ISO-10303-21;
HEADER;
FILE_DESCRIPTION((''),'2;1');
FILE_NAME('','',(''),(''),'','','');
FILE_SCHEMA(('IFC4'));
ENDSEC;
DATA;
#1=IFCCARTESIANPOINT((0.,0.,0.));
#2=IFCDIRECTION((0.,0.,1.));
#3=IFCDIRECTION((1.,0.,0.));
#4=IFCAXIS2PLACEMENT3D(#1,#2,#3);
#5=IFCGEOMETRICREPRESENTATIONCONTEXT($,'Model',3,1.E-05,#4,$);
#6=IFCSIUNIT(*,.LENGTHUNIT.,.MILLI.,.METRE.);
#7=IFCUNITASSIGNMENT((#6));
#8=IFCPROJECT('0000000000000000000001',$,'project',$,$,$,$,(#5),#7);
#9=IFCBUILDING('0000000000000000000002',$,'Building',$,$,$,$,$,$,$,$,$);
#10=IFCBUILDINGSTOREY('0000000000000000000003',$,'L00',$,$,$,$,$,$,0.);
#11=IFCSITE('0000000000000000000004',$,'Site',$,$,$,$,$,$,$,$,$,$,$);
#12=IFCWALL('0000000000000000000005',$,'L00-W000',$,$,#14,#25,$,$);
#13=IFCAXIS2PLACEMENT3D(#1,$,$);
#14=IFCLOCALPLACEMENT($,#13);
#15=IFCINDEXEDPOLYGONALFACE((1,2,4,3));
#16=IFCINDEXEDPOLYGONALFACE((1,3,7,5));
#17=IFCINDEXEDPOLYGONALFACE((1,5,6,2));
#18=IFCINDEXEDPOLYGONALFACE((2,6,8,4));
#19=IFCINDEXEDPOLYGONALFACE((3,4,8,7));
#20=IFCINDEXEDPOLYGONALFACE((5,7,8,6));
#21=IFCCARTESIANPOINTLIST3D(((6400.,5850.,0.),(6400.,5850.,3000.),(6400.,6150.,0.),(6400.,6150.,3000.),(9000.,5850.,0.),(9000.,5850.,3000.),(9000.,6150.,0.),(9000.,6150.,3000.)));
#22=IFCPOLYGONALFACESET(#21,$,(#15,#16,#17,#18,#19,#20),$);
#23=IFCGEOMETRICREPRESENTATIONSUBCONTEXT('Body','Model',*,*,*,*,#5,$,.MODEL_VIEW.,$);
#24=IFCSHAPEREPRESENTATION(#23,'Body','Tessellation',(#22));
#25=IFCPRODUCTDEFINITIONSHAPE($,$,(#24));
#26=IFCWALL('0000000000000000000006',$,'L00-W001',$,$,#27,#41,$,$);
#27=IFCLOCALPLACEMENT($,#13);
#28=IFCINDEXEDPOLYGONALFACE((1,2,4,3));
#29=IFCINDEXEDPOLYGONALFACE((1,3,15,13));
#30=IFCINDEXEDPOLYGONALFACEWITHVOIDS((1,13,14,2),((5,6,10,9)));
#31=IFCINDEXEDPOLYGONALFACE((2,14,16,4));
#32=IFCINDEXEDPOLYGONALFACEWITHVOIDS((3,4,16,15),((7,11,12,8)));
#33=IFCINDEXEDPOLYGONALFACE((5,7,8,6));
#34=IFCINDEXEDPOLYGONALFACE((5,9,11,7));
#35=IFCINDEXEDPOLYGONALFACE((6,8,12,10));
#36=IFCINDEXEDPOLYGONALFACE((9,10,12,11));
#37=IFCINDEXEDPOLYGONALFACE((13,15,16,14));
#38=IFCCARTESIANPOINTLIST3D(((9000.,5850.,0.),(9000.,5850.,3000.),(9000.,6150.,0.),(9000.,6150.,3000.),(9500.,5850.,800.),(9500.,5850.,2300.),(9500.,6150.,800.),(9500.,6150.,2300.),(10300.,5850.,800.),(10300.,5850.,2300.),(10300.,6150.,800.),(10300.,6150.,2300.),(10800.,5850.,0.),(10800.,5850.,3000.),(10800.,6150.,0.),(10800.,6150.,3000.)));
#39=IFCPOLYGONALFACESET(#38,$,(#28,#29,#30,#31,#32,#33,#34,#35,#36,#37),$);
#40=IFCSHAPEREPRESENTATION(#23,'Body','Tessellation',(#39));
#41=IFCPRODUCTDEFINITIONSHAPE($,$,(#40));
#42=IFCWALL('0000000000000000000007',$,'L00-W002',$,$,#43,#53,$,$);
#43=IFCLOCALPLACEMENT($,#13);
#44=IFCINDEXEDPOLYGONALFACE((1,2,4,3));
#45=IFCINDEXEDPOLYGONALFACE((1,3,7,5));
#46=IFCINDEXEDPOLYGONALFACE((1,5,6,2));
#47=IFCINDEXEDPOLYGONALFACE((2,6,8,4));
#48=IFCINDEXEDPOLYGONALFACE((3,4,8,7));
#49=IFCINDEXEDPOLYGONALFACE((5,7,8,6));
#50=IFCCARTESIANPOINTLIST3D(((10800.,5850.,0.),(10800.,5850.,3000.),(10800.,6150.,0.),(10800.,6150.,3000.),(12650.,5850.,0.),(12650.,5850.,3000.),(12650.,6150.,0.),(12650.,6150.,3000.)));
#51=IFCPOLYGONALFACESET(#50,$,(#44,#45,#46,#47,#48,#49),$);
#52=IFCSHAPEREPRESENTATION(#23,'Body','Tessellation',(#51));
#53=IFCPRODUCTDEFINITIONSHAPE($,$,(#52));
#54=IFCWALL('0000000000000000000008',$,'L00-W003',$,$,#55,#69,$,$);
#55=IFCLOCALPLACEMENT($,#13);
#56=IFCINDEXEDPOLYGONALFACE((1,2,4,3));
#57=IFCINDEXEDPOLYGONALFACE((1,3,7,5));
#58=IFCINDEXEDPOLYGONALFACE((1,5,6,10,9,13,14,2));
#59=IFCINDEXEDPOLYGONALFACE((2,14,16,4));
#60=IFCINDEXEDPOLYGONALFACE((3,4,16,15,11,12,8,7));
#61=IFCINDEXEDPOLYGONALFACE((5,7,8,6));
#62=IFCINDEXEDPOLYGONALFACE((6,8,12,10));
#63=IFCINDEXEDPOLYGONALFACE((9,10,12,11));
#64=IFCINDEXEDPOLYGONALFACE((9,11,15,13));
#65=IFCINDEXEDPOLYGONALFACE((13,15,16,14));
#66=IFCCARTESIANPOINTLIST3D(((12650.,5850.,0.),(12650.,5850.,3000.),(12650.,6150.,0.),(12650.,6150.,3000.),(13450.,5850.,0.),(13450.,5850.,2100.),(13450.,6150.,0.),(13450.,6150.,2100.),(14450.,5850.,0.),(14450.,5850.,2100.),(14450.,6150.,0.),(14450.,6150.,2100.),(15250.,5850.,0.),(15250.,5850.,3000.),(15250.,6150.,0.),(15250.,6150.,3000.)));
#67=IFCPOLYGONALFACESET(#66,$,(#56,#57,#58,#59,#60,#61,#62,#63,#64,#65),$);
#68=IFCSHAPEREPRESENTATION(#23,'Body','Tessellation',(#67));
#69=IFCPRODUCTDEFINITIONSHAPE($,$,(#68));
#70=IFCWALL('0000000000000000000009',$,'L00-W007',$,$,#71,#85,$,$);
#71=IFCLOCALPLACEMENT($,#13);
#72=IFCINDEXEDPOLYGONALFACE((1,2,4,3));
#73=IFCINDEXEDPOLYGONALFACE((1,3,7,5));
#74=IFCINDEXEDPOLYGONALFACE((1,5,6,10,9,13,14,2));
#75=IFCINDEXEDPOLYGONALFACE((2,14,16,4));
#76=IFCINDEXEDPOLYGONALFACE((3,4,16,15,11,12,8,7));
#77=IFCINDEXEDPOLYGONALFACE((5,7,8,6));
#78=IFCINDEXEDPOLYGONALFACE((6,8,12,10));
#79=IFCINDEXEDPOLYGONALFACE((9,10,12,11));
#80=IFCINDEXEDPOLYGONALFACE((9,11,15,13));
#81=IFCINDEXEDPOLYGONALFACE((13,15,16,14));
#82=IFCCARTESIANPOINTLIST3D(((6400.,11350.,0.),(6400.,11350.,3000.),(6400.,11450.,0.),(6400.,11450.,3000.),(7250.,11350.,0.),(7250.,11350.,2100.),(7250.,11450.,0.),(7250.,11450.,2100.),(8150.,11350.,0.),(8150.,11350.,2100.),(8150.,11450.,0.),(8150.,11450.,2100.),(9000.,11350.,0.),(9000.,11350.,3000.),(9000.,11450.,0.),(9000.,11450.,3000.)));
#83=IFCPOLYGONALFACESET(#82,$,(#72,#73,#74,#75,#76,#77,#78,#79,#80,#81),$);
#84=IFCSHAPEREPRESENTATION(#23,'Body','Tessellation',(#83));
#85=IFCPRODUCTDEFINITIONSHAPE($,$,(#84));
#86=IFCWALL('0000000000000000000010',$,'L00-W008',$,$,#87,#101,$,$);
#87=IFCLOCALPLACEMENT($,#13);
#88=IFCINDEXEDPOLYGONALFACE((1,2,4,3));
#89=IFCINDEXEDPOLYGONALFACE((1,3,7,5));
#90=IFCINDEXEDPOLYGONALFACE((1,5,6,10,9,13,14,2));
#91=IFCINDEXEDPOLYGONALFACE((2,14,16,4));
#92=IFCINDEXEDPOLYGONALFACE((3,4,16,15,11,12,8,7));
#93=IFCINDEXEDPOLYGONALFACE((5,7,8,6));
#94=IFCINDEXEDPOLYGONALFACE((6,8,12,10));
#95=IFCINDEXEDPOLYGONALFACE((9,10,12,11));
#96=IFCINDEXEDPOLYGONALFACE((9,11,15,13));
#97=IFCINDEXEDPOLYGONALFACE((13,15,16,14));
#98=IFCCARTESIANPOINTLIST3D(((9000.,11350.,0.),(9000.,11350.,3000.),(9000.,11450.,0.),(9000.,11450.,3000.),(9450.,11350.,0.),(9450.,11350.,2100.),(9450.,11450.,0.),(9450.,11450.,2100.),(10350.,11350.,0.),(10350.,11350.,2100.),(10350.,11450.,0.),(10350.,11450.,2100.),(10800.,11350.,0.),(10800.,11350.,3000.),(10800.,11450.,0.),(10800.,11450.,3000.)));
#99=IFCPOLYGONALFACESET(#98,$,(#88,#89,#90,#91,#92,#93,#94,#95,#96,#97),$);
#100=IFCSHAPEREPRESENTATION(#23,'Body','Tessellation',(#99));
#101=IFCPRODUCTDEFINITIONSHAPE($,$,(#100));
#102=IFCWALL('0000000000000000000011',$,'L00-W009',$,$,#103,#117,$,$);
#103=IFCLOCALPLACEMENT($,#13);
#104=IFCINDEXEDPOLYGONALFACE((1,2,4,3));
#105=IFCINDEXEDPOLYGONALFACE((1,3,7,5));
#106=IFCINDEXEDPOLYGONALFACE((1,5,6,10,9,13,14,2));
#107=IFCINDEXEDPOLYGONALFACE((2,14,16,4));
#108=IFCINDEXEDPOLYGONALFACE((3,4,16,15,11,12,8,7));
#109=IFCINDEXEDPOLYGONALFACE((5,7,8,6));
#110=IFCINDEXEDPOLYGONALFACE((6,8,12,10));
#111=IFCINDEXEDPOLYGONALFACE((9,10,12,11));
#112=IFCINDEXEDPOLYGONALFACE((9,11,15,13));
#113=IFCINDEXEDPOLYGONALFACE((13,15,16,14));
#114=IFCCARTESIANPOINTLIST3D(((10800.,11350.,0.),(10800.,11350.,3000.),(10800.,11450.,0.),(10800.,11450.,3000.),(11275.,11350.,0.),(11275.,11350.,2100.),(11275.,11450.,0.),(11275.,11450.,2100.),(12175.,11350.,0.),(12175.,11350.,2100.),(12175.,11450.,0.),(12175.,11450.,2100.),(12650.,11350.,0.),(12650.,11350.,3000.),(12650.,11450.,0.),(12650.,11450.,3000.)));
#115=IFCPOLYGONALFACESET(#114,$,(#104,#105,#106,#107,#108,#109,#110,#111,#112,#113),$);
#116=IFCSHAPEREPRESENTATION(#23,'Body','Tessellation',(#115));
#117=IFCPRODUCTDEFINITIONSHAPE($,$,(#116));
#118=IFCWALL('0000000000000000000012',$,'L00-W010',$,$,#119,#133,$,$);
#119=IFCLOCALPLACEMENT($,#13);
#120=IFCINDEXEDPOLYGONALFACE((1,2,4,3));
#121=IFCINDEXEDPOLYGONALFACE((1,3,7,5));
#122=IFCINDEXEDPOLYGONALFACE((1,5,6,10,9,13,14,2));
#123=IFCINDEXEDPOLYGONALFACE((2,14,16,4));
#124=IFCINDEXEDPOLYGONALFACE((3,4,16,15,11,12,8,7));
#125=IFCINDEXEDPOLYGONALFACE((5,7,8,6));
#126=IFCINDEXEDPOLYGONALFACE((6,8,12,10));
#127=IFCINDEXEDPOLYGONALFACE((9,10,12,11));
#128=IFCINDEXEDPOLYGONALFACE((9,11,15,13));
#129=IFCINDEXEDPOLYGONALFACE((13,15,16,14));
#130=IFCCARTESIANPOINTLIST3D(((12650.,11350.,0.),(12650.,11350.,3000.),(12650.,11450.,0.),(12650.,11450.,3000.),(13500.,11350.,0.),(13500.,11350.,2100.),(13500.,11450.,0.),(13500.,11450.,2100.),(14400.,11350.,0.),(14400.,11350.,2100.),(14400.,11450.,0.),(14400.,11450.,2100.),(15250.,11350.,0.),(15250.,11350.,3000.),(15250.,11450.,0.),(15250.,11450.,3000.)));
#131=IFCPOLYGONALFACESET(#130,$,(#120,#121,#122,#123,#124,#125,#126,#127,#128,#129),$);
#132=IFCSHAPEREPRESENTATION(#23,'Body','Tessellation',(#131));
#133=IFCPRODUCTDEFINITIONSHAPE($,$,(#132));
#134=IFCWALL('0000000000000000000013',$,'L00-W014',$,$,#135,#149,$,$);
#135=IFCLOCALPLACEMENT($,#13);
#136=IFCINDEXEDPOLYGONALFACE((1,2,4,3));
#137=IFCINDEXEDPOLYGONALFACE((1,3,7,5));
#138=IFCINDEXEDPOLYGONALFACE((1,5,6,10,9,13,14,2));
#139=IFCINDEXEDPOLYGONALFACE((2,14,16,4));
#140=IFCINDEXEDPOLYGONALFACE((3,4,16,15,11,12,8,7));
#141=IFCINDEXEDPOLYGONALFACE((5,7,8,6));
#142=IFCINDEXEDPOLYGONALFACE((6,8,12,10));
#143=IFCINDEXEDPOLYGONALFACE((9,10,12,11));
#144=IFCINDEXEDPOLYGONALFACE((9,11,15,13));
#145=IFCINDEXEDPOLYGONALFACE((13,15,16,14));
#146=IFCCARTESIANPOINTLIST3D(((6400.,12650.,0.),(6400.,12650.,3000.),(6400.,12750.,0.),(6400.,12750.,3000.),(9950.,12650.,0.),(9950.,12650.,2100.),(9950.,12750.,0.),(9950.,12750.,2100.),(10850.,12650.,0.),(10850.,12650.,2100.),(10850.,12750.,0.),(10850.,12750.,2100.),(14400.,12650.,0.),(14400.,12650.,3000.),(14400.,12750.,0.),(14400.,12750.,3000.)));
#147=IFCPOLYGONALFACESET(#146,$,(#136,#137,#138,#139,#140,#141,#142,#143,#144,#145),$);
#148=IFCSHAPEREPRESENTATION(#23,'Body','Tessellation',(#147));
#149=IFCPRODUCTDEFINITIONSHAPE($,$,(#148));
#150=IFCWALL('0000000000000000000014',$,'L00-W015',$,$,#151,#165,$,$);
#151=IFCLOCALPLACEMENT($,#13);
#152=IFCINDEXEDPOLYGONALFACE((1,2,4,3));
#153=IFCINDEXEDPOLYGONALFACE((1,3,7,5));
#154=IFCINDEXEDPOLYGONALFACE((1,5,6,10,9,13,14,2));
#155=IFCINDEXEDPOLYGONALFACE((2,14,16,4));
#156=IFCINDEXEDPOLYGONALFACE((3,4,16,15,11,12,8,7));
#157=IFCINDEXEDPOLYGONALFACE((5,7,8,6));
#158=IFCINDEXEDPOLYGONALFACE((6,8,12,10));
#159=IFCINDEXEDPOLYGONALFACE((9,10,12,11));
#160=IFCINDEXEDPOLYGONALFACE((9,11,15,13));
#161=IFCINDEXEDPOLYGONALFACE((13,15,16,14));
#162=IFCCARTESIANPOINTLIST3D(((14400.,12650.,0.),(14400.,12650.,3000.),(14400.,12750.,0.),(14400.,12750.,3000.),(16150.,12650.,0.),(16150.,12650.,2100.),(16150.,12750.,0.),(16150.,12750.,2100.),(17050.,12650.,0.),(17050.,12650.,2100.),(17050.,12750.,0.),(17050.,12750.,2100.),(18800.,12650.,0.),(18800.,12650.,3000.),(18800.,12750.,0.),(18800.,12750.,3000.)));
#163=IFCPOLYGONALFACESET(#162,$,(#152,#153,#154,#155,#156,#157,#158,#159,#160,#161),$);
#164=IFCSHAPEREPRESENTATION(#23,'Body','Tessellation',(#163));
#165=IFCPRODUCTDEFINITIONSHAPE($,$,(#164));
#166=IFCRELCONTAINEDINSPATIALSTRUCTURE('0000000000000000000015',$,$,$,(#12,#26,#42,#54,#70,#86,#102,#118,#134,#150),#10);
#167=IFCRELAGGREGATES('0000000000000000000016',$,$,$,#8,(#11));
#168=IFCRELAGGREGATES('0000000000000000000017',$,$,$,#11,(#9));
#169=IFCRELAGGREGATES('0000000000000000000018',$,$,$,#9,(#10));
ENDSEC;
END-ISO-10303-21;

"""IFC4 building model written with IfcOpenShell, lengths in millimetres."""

from ifc_helpers import new_model, si_unit, frame, origin_with_axes, place, context, subcontext, project, spatial, indexed_curve, outline, extrude, element, save


model = new_model("IFC4")

# Units and contexts
model_context = context("Model", 3, precision=1e-05, world=origin_with_axes())
body_context = subcontext(model_context, "Body", "Model", "MODEL_VIEW")
ifc_project = project(units=[si_unit("LENGTHUNIT", "METRE", prefix="MILLI")], contexts=[model_context])

# Site, building, storey
site = spatial("IfcSite", under=ifc_project, Name="Site")
building = spatial("IfcBuilding", under=site, Name="Building")
storey = spatial("IfcBuildingStorey", under=building, Name="L00", Elevation=0.0)

# Wall
wall_1_placement = place(None, frame((6400.0, 5850.0, 0.0), z_axis=(0.0, 0.0, 1.0), x_axis=(1.0, 0.0, 0.0)))
element("IfcWall", 1, at=wall_1_placement, inside=storey, Name="L00-W000", context=body_context, shape_type="SweptSolid", body=[
    extrude(outline(indexed_curve([(0.0, 0.0), (0.0, 300.0), (2600.0, 300.0), (2600.0, 0.0), (0.0, 0.0)], self_intersect=False)), origin_with_axes(), (0.0, 0.0, 1.0), 3000.0),
])

# Wall, opening
wall_2_placement = place(None, frame((9000.0, 5850.0, 0.0), z_axis=(0.0, 0.0, 1.0), x_axis=(1.0, 0.0, 0.0)))
wall_2 = element("IfcWall", 2, at=wall_2_placement, inside=storey, Name="L00-W001", context=body_context, shape_type="SweptSolid", body=[
    extrude(outline(indexed_curve([(0.0, 0.0), (0.0, 300.0), (1800.0, 300.0), (1800.0, 0.0), (0.0, 0.0)], self_intersect=False)), origin_with_axes(), (0.0, 0.0, 1.0), 3000.0),
])
opening_1_placement = place(wall_2_placement, frame((500.0, -10.0, 800.0), z_axis=(0.0, 0.0, 1.0), x_axis=(1.0, 0.0, 0.0)))
element("IfcOpeningElement", 3, at=opening_1_placement, cuts=wall_2, context=body_context, shape_type="SweptSolid", body=[
    extrude(outline(indexed_curve([(0.0, 0.0), (0.0, 320.0), (800.0, 320.0), (800.0, 0.0), (0.0, 0.0)], self_intersect=False)), origin_with_axes(), (0.0, 0.0, 1.0), 1500.0),
])

# Wall
wall_3_placement = place(None, frame((10800.0, 5850.0, 0.0), z_axis=(0.0, 0.0, 1.0), x_axis=(1.0, 0.0, 0.0)))
element("IfcWall", 4, at=wall_3_placement, inside=storey, Name="L00-W002", context=body_context, shape_type="SweptSolid", body=[
    extrude(outline(indexed_curve([(0.0, 0.0), (0.0, 300.0), (1850.0, 300.0), (1850.0, 0.0), (0.0, 0.0)], self_intersect=False)), origin_with_axes(), (0.0, 0.0, 1.0), 3000.0),
])

# Walls, openings
wall_4_placement = place(None, frame((12650.0, 5850.0, 0.0), z_axis=(0.0, 0.0, 1.0), x_axis=(1.0, 0.0, 0.0)))
wall_4 = element("IfcWall", 5, at=wall_4_placement, inside=storey, Name="L00-W003", context=body_context, shape_type="SweptSolid", body=[
    extrude(outline(indexed_curve([(0.0, 0.0), (0.0, 300.0), (2600.0, 300.0), (2600.0, 0.0), (0.0, 0.0)], self_intersect=False)), origin_with_axes(), (0.0, 0.0, 1.0), 3000.0),
])
opening_2_placement = place(wall_4_placement, frame((800.0, -10.0, 0.0), z_axis=(0.0, 0.0, 1.0), x_axis=(1.0, 0.0, 0.0)))
element("IfcOpeningElement", 6, at=opening_2_placement, cuts=wall_4, context=body_context, shape_type="SweptSolid", body=[
    extrude(outline(indexed_curve([(0.0, 0.0), (0.0, 320.0), (1000.0, 320.0), (1000.0, 0.0), (0.0, 0.0)], self_intersect=False)), origin_with_axes(), (0.0, 0.0, 1.0), 2100.0),
])
wall_5_placement = place(None, frame((6400.0, 11350.0, 0.0), z_axis=(0.0, 0.0, 1.0), x_axis=(1.0, 0.0, 0.0)))
wall_5 = element("IfcWall", 7, at=wall_5_placement, inside=storey, Name="L00-W007", context=body_context, shape_type="SweptSolid", body=[
    extrude(outline(indexed_curve([(0.0, 0.0), (0.0, 100.0), (2600.0, 100.0), (2600.0, 0.0), (0.0, 0.0)], self_intersect=False)), origin_with_axes(), (0.0, 0.0, 1.0), 3000.0),
])
opening_3_placement = place(wall_5_placement, frame((850.0, -10.0, 0.0), z_axis=(0.0, 0.0, 1.0), x_axis=(1.0, 0.0, 0.0)))
element("IfcOpeningElement", 8, at=opening_3_placement, cuts=wall_5, context=body_context, shape_type="SweptSolid", body=[
    extrude(outline(indexed_curve([(0.0, 0.0), (0.0, 120.0), (900.0, 120.0), (900.0, 0.0), (0.0, 0.0)], self_intersect=False)), origin_with_axes(), (0.0, 0.0, 1.0), 2100.0),
])
wall_6_placement = place(None, frame((9000.0, 11350.0, 0.0), z_axis=(0.0, 0.0, 1.0), x_axis=(1.0, 0.0, 0.0)))
wall_6 = element("IfcWall", 9, at=wall_6_placement, inside=storey, Name="L00-W008", context=body_context, shape_type="SweptSolid", body=[
    extrude(outline(indexed_curve([(0.0, 0.0), (0.0, 100.0), (1800.0, 100.0), (1800.0, 0.0), (0.0, 0.0)], self_intersect=False)), origin_with_axes(), (0.0, 0.0, 1.0), 3000.0),
])
opening_4_placement = place(wall_6_placement, frame((450.0, -10.0, 0.0), z_axis=(0.0, 0.0, 1.0), x_axis=(1.0, 0.0, 0.0)))
element("IfcOpeningElement", 10, at=opening_4_placement, cuts=wall_6, context=body_context, shape_type="SweptSolid", body=[
    extrude(outline(indexed_curve([(0.0, 0.0), (0.0, 120.0), (900.0, 120.0), (900.0, 0.0), (0.0, 0.0)], self_intersect=False)), origin_with_axes(), (0.0, 0.0, 1.0), 2100.0),
])
wall_7_placement = place(None, frame((10800.0, 11350.0, 0.0), z_axis=(0.0, 0.0, 1.0), x_axis=(1.0, 0.0, 0.0)))
wall_7 = element("IfcWall", 11, at=wall_7_placement, inside=storey, Name="L00-W009", context=body_context, shape_type="SweptSolid", body=[
    extrude(outline(indexed_curve([(0.0, 0.0), (0.0, 100.0), (1850.0, 100.0), (1850.0, 0.0), (0.0, 0.0)], self_intersect=False)), origin_with_axes(), (0.0, 0.0, 1.0), 3000.0),
])
opening_5_placement = place(wall_7_placement, frame((475.0, -10.0, 0.0), z_axis=(0.0, 0.0, 1.0), x_axis=(1.0, 0.0, 0.0)))
element("IfcOpeningElement", 12, at=opening_5_placement, cuts=wall_7, context=body_context, shape_type="SweptSolid", body=[
    extrude(outline(indexed_curve([(0.0, 0.0), (0.0, 120.0), (900.0, 120.0), (900.0, 0.0), (0.0, 0.0)], self_intersect=False)), origin_with_axes(), (0.0, 0.0, 1.0), 2100.0),
])
wall_8_placement = place(None, frame((12650.0, 11350.0, 0.0), z_axis=(0.0, 0.0, 1.0), x_axis=(1.0, 0.0, 0.0)))
wall_8 = element("IfcWall", 13, at=wall_8_placement, inside=storey, Name="L00-W010", context=body_context, shape_type="SweptSolid", body=[
    extrude(outline(indexed_curve([(0.0, 0.0), (0.0, 100.0), (2600.0, 100.0), (2600.0, 0.0), (0.0, 0.0)], self_intersect=False)), origin_with_axes(), (0.0, 0.0, 1.0), 3000.0),
])
opening_6_placement = place(wall_8_placement, frame((850.0, -10.0, 0.0), z_axis=(0.0, 0.0, 1.0), x_axis=(1.0, 0.0, 0.0)))
element("IfcOpeningElement", 14, at=opening_6_placement, cuts=wall_8, context=body_context, shape_type="SweptSolid", body=[
    extrude(outline(indexed_curve([(0.0, 0.0), (0.0, 120.0), (900.0, 120.0), (900.0, 0.0), (0.0, 0.0)], self_intersect=False)), origin_with_axes(), (0.0, 0.0, 1.0), 2100.0),
])
wall_9_placement = place(None, frame((6400.0, 12650.0, 0.0), z_axis=(0.0, 0.0, 1.0), x_axis=(1.0, 0.0, 0.0)))
wall_9 = element("IfcWall", 15, at=wall_9_placement, inside=storey, Name="L00-W014", context=body_context, shape_type="SweptSolid", body=[
    extrude(outline(indexed_curve([(0.0, 0.0), (0.0, 100.0), (8000.0, 100.0), (8000.0, 0.0), (0.0, 0.0)], self_intersect=False)), origin_with_axes(), (0.0, 0.0, 1.0), 3000.0),
])
opening_7_placement = place(wall_9_placement, frame((3550.0, -10.0, 0.0), z_axis=(0.0, 0.0, 1.0), x_axis=(1.0, 0.0, 0.0)))
element("IfcOpeningElement", 16, at=opening_7_placement, cuts=wall_9, context=body_context, shape_type="SweptSolid", body=[
    extrude(outline(indexed_curve([(0.0, 0.0), (0.0, 120.0), (900.0, 120.0), (900.0, 0.0), (0.0, 0.0)], self_intersect=False)), origin_with_axes(), (0.0, 0.0, 1.0), 2100.0),
])
wall_10_placement = place(None, frame((14400.0, 12650.0, 0.0), z_axis=(0.0, 0.0, 1.0), x_axis=(1.0, 0.0, 0.0)))
wall_10 = element("IfcWall", 17, at=wall_10_placement, inside=storey, Name="L00-W015", context=body_context, shape_type="SweptSolid", body=[
    extrude(outline(indexed_curve([(0.0, 0.0), (0.0, 100.0), (4400.0, 100.0), (4400.0, 0.0), (0.0, 0.0)], self_intersect=False)), origin_with_axes(), (0.0, 0.0, 1.0), 3000.0),
])
opening_8_placement = place(wall_10_placement, frame((1750.0, -10.0, 0.0), z_axis=(0.0, 0.0, 1.0), x_axis=(1.0, 0.0, 0.0)))
element("IfcOpeningElement", 18, at=opening_8_placement, cuts=wall_10, context=body_context, shape_type="SweptSolid", body=[
    extrude(outline(indexed_curve([(0.0, 0.0), (0.0, 120.0), (900.0, 120.0), (900.0, 0.0), (0.0, 0.0)], self_intersect=False)), origin_with_axes(), (0.0, 0.0, 1.0), 2100.0),
])

save(model, "model.ifc")
